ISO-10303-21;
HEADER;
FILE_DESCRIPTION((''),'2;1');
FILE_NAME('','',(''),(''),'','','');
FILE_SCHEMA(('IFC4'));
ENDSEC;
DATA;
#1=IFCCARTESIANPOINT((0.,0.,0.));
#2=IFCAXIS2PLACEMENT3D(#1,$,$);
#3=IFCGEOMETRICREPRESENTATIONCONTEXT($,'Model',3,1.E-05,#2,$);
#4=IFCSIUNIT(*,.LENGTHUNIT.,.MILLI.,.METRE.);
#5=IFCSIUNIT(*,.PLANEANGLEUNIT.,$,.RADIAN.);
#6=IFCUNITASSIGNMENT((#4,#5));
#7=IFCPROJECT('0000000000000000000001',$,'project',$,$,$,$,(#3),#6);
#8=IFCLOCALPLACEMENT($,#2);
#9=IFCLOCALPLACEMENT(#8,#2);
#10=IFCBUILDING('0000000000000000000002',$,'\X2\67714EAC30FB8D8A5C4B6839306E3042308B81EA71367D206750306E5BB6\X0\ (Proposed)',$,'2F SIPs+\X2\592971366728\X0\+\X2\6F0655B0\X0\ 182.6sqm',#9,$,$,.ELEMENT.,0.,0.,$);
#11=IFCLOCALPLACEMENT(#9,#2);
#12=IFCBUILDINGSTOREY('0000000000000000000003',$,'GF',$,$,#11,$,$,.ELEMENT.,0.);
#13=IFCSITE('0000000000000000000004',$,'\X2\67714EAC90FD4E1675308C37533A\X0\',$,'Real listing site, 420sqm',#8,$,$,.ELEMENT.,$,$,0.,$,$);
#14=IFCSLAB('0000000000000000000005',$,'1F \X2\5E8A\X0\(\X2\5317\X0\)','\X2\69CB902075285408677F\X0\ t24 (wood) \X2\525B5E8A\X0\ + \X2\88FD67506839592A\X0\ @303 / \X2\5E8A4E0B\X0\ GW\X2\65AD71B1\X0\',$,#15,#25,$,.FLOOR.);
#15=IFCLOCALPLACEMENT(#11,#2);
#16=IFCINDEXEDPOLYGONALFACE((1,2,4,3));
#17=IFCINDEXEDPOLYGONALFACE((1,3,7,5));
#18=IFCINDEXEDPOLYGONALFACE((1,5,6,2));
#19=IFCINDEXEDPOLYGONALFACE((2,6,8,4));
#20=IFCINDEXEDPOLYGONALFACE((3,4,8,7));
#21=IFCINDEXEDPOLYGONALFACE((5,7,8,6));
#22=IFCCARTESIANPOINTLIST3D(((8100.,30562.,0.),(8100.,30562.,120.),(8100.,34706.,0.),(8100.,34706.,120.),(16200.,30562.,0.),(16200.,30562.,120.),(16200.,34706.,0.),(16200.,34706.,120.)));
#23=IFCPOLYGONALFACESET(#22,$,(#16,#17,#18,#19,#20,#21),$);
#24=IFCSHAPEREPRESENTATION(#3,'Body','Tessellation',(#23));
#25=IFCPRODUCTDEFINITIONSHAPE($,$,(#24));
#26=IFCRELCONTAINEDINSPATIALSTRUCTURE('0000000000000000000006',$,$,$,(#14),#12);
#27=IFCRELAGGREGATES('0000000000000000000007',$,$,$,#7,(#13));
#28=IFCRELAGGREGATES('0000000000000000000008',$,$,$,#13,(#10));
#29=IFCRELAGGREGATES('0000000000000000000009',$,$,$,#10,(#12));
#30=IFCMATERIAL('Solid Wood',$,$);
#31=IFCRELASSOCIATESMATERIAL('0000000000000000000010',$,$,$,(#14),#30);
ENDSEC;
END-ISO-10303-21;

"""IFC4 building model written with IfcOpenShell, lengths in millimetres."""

from ifc_helpers import new_model, si_unit, frame, frame_2d, origin, place, context, project, spatial, rectangle, extrude, material, element, save


model = new_model("IFC4")

# Units and contexts
model_context = context("Model", 3, precision=1e-05, world=origin())
ifc_project = project(units=[si_unit("LENGTHUNIT", "METRE", prefix="MILLI"), si_unit("PLANEANGLEUNIT", "RADIAN")], contexts=[model_context])

# Site, building, storey
site_placement = place(None, origin())
site = spatial("IfcSite", under=ifc_project, at=site_placement, Name="東京都世田谷区", ObjectType="Real listing site, 420sqm", CompositionType="ELEMENT", RefElevation=0.0)
building_placement = place(site_placement, origin())
building = spatial("IfcBuilding", under=site, at=building_placement, Name="東京・越屋根のある自然素材の家 (Proposed)", ObjectType="2F SIPs+天然木+漆喰 182.6sqm", CompositionType="ELEMENT", ElevationOfRefHeight=0.0, ElevationOfTerrain=0.0)
storey_placement = place(building_placement, origin())
storey = spatial("IfcBuildingStorey", under=building, at=storey_placement, Name="GF", CompositionType="ELEMENT", Elevation=0.0)

# Shared definitions
ifc_material_1 = material(Name="Solid Wood")

# Slab
slab_1_placement = place(storey_placement, frame((4050.0, 15281.0, 0.0)))
element("IfcSlab", 1, at=slab_1_placement, inside=storey, material=ifc_material_1, Name="1F 床(北)", Description="構造用合板 t24 (wood) 剛床 + 製材根太 @303 / 床下 GW断熱", PredefinedType="FLOOR", context=model_context, shape_type="SweptSolid", body=[
    extrude(rectangle(XDim=8100.0, YDim=4144.0, at=frame_2d((4050.0, 2072.0))), frame((4050.0, 15281.0, 0.0)), (0.0, 0.0, 1.0), 120.0),
])

save(model, "model.ifc")
